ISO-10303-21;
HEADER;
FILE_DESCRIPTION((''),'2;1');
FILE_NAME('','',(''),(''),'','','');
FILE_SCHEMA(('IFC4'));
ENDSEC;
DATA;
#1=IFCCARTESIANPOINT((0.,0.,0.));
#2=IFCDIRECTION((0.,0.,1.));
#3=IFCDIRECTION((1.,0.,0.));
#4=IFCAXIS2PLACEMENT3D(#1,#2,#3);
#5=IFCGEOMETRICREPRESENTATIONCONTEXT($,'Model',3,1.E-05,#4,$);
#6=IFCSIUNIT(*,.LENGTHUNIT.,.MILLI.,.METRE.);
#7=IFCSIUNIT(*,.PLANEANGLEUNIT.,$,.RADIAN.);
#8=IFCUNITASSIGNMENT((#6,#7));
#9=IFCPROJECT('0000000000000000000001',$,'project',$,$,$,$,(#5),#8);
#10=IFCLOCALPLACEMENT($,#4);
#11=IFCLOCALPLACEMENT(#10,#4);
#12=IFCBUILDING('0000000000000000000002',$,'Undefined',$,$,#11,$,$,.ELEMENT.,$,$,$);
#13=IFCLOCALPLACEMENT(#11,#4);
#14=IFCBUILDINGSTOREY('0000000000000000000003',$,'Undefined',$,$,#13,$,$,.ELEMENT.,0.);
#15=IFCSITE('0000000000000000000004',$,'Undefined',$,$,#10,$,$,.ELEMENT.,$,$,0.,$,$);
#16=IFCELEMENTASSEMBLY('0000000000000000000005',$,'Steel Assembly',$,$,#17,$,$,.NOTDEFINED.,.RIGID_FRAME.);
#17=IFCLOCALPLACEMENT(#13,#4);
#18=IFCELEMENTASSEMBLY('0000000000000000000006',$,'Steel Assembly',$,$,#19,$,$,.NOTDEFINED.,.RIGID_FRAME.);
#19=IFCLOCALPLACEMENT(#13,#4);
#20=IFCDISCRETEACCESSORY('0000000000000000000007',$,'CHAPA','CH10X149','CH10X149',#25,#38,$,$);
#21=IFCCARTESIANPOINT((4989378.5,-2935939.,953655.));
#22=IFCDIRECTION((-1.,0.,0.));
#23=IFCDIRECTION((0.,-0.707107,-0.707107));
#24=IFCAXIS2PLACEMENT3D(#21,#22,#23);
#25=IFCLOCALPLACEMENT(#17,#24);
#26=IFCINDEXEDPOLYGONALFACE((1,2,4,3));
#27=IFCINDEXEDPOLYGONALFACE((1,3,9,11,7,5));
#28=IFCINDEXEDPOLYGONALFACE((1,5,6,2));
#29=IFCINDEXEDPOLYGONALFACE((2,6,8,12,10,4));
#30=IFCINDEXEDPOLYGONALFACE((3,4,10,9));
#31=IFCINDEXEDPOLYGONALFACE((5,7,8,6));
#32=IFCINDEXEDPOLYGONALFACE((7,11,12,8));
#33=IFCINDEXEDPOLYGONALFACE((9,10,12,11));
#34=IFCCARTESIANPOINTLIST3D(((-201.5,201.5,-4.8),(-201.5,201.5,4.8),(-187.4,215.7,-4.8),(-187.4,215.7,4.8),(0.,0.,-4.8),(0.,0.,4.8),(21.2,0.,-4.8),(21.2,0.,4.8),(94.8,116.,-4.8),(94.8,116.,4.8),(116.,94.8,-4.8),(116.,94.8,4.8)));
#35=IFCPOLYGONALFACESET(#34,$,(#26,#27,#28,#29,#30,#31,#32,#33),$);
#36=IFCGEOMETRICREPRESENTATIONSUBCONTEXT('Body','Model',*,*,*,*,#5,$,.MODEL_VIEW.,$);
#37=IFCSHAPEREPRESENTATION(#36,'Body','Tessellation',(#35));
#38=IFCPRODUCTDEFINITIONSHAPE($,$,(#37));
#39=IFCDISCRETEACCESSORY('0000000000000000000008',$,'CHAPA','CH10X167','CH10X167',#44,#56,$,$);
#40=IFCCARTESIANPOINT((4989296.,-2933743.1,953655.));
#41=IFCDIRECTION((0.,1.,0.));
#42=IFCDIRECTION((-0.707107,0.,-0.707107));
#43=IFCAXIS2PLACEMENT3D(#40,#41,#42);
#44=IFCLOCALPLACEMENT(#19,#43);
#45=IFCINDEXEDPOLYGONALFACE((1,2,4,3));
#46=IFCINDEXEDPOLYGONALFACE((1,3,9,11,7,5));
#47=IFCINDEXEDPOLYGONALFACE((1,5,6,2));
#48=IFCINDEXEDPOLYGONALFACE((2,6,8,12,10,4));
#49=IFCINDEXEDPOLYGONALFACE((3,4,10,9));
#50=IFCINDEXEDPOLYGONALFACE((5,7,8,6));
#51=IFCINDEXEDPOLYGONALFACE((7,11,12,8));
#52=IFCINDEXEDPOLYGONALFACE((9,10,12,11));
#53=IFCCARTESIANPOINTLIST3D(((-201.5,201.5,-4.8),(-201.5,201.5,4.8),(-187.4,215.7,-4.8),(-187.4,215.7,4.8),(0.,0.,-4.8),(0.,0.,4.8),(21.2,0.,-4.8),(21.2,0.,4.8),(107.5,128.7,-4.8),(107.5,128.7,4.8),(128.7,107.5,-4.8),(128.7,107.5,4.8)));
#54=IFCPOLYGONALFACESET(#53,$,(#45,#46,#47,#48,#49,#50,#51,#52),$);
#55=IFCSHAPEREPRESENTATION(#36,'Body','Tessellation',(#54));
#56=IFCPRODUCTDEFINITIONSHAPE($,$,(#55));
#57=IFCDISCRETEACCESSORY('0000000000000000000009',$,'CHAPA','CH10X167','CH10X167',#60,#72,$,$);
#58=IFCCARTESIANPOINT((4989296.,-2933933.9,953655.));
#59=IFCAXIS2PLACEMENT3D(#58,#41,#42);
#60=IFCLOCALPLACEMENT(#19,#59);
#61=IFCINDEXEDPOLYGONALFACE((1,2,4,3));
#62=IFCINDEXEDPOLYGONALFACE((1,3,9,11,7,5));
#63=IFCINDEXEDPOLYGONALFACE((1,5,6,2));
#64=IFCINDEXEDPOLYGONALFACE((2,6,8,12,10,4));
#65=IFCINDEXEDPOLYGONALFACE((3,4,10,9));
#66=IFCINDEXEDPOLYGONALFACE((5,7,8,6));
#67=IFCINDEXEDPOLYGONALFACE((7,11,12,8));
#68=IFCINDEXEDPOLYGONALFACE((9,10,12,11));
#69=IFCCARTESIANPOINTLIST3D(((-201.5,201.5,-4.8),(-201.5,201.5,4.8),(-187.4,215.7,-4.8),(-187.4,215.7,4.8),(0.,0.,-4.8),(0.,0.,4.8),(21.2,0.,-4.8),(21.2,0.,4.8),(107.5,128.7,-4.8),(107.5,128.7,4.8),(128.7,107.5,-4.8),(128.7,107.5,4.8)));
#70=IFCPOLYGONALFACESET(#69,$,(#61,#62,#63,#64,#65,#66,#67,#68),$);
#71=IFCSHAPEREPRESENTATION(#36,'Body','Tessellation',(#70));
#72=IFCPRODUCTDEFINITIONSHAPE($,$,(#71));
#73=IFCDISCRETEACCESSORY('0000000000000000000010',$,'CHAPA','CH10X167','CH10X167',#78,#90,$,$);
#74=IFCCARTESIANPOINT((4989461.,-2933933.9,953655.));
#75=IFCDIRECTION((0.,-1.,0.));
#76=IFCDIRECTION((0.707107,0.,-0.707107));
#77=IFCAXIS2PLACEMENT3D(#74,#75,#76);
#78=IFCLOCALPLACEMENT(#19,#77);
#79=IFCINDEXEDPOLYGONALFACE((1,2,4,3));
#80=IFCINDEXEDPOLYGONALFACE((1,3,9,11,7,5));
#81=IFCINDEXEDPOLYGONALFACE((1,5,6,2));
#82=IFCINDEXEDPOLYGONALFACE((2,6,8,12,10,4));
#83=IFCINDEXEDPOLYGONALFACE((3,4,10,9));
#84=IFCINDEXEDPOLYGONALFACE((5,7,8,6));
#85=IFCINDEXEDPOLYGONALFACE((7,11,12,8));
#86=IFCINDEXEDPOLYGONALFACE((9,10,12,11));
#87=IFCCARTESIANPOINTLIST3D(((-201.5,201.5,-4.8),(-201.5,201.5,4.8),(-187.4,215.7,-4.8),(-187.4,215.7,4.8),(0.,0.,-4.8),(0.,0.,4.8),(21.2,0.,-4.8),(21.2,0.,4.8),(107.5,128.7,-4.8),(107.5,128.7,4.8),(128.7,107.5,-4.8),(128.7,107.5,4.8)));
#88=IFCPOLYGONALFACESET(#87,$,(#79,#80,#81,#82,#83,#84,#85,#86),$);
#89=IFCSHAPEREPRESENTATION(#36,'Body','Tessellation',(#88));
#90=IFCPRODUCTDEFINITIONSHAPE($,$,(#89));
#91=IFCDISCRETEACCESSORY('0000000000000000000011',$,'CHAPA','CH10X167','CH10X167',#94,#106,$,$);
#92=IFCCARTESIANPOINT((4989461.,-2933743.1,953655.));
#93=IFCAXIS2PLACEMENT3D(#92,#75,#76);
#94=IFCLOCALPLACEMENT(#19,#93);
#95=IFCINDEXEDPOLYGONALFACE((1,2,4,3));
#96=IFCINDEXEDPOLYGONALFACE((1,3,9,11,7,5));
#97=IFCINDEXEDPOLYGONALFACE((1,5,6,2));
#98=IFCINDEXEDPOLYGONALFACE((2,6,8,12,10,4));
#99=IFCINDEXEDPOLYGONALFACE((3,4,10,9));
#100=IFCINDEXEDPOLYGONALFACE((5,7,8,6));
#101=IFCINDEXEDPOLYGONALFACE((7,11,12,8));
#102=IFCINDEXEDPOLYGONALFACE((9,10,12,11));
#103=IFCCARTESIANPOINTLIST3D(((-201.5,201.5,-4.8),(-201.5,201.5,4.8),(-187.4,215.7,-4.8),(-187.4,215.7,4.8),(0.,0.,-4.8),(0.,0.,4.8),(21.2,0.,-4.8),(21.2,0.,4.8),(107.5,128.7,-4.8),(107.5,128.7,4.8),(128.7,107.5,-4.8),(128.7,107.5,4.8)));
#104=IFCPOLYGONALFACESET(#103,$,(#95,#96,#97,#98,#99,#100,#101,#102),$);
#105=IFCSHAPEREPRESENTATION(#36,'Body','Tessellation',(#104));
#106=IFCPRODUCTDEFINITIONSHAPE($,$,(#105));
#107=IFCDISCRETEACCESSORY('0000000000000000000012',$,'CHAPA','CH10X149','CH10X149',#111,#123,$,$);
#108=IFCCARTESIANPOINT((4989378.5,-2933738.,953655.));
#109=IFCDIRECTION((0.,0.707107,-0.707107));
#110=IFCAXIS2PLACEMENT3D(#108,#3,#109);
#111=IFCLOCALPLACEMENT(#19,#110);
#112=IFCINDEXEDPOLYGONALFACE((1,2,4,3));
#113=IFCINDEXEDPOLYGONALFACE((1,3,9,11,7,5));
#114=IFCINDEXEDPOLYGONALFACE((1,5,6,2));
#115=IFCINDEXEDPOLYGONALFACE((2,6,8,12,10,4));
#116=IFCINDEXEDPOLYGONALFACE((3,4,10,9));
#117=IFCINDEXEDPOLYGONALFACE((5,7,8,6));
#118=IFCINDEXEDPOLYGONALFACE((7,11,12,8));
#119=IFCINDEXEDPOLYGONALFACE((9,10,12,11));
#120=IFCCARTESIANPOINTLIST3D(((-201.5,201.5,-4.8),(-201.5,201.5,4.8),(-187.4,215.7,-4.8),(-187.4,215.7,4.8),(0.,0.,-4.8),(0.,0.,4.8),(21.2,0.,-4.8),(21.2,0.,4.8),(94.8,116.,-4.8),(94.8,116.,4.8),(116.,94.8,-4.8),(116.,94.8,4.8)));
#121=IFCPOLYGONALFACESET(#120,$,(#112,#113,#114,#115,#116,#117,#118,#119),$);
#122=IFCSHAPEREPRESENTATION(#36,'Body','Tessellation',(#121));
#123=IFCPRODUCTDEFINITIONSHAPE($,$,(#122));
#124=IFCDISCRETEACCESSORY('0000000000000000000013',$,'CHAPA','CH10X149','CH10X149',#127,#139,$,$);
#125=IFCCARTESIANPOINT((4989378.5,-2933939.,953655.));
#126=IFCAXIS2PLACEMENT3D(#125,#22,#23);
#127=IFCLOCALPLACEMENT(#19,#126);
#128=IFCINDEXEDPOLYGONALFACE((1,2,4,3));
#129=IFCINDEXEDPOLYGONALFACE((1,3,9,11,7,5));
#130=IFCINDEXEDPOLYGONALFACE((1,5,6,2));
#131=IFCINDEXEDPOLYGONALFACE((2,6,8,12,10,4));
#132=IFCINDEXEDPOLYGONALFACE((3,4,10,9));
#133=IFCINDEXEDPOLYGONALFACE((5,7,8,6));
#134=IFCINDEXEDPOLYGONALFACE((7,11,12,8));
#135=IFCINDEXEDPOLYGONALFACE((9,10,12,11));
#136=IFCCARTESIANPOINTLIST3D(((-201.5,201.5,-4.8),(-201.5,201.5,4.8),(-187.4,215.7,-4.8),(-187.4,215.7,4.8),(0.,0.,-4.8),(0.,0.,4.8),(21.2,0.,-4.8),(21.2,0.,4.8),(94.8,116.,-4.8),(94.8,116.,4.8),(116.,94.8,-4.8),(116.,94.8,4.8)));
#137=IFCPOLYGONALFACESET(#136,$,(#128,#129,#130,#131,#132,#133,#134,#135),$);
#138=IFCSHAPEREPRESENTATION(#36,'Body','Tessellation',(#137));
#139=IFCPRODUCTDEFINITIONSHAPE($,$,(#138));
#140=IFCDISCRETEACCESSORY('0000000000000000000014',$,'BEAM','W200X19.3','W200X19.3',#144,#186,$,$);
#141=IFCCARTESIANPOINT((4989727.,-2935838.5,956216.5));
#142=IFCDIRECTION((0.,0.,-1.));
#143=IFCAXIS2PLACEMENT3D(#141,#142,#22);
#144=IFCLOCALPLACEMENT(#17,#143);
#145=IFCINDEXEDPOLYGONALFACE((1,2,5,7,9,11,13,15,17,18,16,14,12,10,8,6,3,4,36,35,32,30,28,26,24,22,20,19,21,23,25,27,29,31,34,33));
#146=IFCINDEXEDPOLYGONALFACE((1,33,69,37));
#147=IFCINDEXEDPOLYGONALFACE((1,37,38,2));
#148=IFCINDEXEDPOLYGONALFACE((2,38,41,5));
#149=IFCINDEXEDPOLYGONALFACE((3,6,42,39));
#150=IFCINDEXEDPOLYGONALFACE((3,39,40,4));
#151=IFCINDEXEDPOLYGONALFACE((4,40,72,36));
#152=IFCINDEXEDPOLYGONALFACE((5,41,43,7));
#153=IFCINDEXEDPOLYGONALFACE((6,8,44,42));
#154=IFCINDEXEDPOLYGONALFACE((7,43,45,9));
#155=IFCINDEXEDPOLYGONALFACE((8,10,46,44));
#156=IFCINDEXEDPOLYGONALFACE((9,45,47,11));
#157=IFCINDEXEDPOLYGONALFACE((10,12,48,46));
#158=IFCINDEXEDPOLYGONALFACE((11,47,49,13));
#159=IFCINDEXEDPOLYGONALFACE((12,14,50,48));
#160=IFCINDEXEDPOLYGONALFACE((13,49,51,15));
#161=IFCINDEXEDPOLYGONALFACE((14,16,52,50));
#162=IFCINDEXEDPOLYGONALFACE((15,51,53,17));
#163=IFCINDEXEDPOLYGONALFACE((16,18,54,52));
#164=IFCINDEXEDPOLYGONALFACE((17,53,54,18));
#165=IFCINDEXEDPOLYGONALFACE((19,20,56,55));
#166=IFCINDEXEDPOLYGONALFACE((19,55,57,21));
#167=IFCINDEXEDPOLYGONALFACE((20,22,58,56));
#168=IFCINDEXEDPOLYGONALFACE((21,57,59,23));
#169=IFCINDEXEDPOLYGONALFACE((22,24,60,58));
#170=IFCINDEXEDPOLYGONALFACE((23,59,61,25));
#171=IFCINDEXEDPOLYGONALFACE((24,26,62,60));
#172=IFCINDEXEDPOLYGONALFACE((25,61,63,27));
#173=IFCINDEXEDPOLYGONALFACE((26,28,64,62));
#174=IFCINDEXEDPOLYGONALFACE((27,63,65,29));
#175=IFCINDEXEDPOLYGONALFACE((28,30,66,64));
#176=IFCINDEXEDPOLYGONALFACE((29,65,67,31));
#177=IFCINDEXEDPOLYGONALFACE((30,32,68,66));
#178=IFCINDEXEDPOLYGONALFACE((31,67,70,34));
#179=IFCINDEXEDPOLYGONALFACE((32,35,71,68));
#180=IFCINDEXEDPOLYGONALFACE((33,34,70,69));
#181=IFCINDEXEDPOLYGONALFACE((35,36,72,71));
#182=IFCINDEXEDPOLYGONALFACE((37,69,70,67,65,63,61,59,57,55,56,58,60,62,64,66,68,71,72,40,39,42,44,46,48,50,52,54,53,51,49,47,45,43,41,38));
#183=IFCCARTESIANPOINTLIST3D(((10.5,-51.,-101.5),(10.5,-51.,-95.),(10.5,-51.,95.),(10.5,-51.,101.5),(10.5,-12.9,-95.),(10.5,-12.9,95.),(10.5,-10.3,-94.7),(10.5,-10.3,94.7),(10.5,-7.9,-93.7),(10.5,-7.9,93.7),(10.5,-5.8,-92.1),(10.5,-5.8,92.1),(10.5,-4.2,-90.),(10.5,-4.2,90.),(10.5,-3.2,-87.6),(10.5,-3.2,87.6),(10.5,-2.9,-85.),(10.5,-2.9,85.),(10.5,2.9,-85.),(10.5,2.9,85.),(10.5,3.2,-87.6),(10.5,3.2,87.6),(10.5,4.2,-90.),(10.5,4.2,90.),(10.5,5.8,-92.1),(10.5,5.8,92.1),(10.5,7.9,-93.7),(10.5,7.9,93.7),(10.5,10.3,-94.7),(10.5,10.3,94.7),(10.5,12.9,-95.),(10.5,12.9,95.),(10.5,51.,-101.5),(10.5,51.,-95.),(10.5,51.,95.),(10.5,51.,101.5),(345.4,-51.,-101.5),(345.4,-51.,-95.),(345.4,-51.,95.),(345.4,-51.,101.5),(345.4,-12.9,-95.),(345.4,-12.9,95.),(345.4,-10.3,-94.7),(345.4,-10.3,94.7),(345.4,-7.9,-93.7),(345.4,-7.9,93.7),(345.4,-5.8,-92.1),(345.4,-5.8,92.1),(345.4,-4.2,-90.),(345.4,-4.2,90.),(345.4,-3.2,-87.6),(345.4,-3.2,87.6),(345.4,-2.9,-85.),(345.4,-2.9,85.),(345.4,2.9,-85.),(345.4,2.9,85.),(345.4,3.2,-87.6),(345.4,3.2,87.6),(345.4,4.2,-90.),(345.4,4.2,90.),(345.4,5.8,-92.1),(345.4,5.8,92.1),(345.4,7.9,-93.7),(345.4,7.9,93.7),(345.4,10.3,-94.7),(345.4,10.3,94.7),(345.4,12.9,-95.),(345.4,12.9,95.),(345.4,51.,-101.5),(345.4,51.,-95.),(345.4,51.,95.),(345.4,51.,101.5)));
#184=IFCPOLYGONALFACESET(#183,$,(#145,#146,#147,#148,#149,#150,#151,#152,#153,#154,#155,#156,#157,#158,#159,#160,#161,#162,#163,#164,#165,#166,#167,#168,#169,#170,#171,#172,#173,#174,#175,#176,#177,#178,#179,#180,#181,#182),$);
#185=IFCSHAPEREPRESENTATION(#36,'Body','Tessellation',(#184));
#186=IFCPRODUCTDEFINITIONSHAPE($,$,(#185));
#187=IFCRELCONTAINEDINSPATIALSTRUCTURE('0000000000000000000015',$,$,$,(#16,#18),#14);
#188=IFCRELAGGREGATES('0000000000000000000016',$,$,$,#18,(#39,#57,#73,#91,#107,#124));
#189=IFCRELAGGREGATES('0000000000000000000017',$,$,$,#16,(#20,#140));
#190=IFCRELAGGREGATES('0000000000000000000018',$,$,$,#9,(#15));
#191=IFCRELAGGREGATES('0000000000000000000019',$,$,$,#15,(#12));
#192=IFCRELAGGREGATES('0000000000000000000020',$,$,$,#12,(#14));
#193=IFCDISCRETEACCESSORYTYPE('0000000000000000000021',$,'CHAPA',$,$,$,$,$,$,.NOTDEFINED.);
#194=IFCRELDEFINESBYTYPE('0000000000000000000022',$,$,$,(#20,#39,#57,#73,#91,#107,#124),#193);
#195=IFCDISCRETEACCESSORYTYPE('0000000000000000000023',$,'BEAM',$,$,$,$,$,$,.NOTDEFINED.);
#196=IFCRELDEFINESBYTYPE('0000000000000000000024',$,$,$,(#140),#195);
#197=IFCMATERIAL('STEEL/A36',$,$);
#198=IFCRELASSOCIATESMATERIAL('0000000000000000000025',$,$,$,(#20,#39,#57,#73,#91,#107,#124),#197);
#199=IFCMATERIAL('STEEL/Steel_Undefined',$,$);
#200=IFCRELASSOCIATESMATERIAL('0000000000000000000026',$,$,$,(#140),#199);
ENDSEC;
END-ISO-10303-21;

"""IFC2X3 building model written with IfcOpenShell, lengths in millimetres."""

from ifc_helpers import new_model, si_unit, frame, origin_with_axes, origin_2d_with_axis, place, context, subcontext, project, spatial, polyline, i_section, outline, extrude, clip, halfspace, material, type_object, element, aggregate, save


model = new_model("IFC2X3")

# Units and contexts
model_context = context("Model", 3, precision=1e-05, world=origin_with_axes())
body_context = subcontext(model_context, "Body", "Model", "MODEL_VIEW")
ifc_project = project(units=[si_unit("LENGTHUNIT", "METRE", prefix="MILLI"), si_unit("PLANEANGLEUNIT", "RADIAN")], contexts=[model_context])

# Site, building, storey
site_placement = place(None, origin_with_axes())
site = spatial("IfcSite", under=ifc_project, at=site_placement, Name="Undefined", CompositionType="ELEMENT", RefElevation=0.0)
building_placement = place(site_placement, origin_with_axes())
building = spatial("IfcBuilding", under=site, at=building_placement, Name="Undefined", CompositionType="ELEMENT")
storey_placement = place(building_placement, origin_with_axes())
storey = spatial("IfcBuildingStorey", under=building, at=storey_placement, Name="Undefined", CompositionType="ELEMENT", Elevation=0.0)

# Element assemblies
assembly_1_placement = place(storey_placement, origin_with_axes())
assembly_1 = element("IfcElementAssembly", 1, at=assembly_1_placement, inside=storey, Name="Steel Assembly", AssemblyPlace="NOTDEFINED", PredefinedType="RIGID_FRAME")
assembly_2_placement = place(storey_placement, origin_with_axes())
assembly_2 = element("IfcElementAssembly", 2, at=assembly_2_placement, inside=storey, Name="Steel Assembly", AssemblyPlace="NOTDEFINED", PredefinedType="RIGID_FRAME")

# Discrete accessories
ifc_material_1 = material(Name="STEEL/A36")
discrete_accessory_type_1 = type_object("IfcDiscreteAccessoryType", Name="CHAPA")
discrete_accessory_1_placement = place(assembly_1_placement, frame((4989378.5, -2935939.0, 953655.0), z_axis=(-1.0, 0.0, 0.0), x_axis=(0.0, -0.707107, -0.707107)))
discrete_accessory_1 = element("IfcDiscreteAccessory", 3, at=discrete_accessory_1_placement, type_object=discrete_accessory_type_1, material=ifc_material_1, Name="CHAPA", Description="CH10X149", ObjectType="CH10X149", context=body_context, shape_type="SweptSolid", body=[
    extrude(outline(polyline([(0.0, 0.0), (21.2, 0.0), (116.0, 94.8), (94.8, 116.0), (-187.4, 215.7), (-201.5, 201.5), (0.0, 0.0)])), frame((0.0, 0.0, -4.8), z_axis=(0.0, 0.0, 1.0), x_axis=(1.0, 0.0, 0.0)), (0.0, 0.0, 1.0), 9.5),
])
discrete_accessory_2_placement = place(assembly_2_placement, frame((4989296.0, -2933743.1, 953655.0), z_axis=(0.0, 1.0, 0.0), x_axis=(-0.707107, 0.0, -0.707107)))
discrete_accessory_2 = element("IfcDiscreteAccessory", 4, at=discrete_accessory_2_placement, type_object=discrete_accessory_type_1, material=ifc_material_1, Name="CHAPA", Description="CH10X167", ObjectType="CH10X167", context=body_context, shape_type="SweptSolid", body=[
    extrude(outline(polyline([(0.0, 0.0), (21.2, 0.0), (128.7, 107.5), (107.5, 128.7), (-187.4, 215.7), (-201.5, 201.5), (0.0, 0.0)])), frame((0.0, 0.0, -4.8), z_axis=(0.0, 0.0, 1.0), x_axis=(1.0, 0.0, 0.0)), (0.0, 0.0, 1.0), 9.5),
])
discrete_accessory_3_placement = place(assembly_2_placement, frame((4989296.0, -2933933.9, 953655.0), z_axis=(0.0, 1.0, 0.0), x_axis=(-0.707107, 0.0, -0.707107)))
discrete_accessory_3 = element("IfcDiscreteAccessory", 5, at=discrete_accessory_3_placement, type_object=discrete_accessory_type_1, material=ifc_material_1, Name="CHAPA", Description="CH10X167", ObjectType="CH10X167", context=body_context, shape_type="SweptSolid", body=[
    extrude(outline(polyline([(0.0, 0.0), (21.2, 0.0), (128.7, 107.5), (107.5, 128.7), (-187.4, 215.7), (-201.5, 201.5), (0.0, 0.0)])), frame((0.0, 0.0, -4.8), z_axis=(0.0, 0.0, 1.0), x_axis=(1.0, 0.0, 0.0)), (0.0, 0.0, 1.0), 9.5),
])
discrete_accessory_4_placement = place(assembly_2_placement, frame((4989461.0, -2933933.9, 953655.0), z_axis=(0.0, -1.0, 0.0), x_axis=(0.707107, 0.0, -0.707107)))
discrete_accessory_4 = element("IfcDiscreteAccessory", 6, at=discrete_accessory_4_placement, type_object=discrete_accessory_type_1, material=ifc_material_1, Name="CHAPA", Description="CH10X167", ObjectType="CH10X167", context=body_context, shape_type="SweptSolid", body=[
    extrude(outline(polyline([(0.0, 0.0), (21.2, 0.0), (128.7, 107.5), (107.5, 128.7), (-187.4, 215.7), (-201.5, 201.5), (0.0, 0.0)])), frame((0.0, 0.0, -4.8), z_axis=(0.0, 0.0, 1.0), x_axis=(1.0, 0.0, 0.0)), (0.0, 0.0, 1.0), 9.5),
])
discrete_accessory_5_placement = place(assembly_2_placement, frame((4989461.0, -2933743.1, 953655.0), z_axis=(0.0, -1.0, 0.0), x_axis=(0.707107, 0.0, -0.707107)))
discrete_accessory_5 = element("IfcDiscreteAccessory", 7, at=discrete_accessory_5_placement, type_object=discrete_accessory_type_1, material=ifc_material_1, Name="CHAPA", Description="CH10X167", ObjectType="CH10X167", context=body_context, shape_type="SweptSolid", body=[
    extrude(outline(polyline([(0.0, 0.0), (21.2, 0.0), (128.7, 107.5), (107.5, 128.7), (-187.4, 215.7), (-201.5, 201.5), (0.0, 0.0)])), frame((0.0, 0.0, -4.8), z_axis=(0.0, 0.0, 1.0), x_axis=(1.0, 0.0, 0.0)), (0.0, 0.0, 1.0), 9.5),
])
discrete_accessory_6_placement = place(assembly_2_placement, frame((4989378.5, -2933738.0, 953655.0), z_axis=(1.0, 0.0, 0.0), x_axis=(0.0, 0.707107, -0.707107)))
discrete_accessory_6 = element("IfcDiscreteAccessory", 8, at=discrete_accessory_6_placement, type_object=discrete_accessory_type_1, material=ifc_material_1, Name="CHAPA", Description="CH10X149", ObjectType="CH10X149", context=body_context, shape_type="SweptSolid", body=[
    extrude(outline(polyline([(0.0, 0.0), (21.2, 0.0), (116.0, 94.8), (94.8, 116.0), (-187.4, 215.7), (-201.5, 201.5), (0.0, 0.0)])), frame((0.0, 0.0, -4.8), z_axis=(0.0, 0.0, 1.0), x_axis=(1.0, 0.0, 0.0)), (0.0, 0.0, 1.0), 9.5),
])
discrete_accessory_7_placement = place(assembly_2_placement, frame((4989378.5, -2933939.0, 953655.0), z_axis=(-1.0, 0.0, 0.0), x_axis=(0.0, -0.707107, -0.707107)))
discrete_accessory_7 = element("IfcDiscreteAccessory", 9, at=discrete_accessory_7_placement, type_object=discrete_accessory_type_1, material=ifc_material_1, Name="CHAPA", Description="CH10X149", ObjectType="CH10X149", context=body_context, shape_type="SweptSolid", body=[
    extrude(outline(polyline([(0.0, 0.0), (21.2, 0.0), (116.0, 94.8), (94.8, 116.0), (-187.4, 215.7), (-201.5, 201.5), (0.0, 0.0)])), frame((0.0, 0.0, -4.8), z_axis=(0.0, 0.0, 1.0), x_axis=(1.0, 0.0, 0.0)), (0.0, 0.0, 1.0), 9.5),
])
aggregate(assembly_2, [discrete_accessory_2, discrete_accessory_3, discrete_accessory_4, discrete_accessory_5, discrete_accessory_6, discrete_accessory_7])

# Discrete accessory
ifc_material_2 = material(Name="STEEL/Steel_Undefined")
discrete_accessory_type_2 = type_object("IfcDiscreteAccessoryType", Name="BEAM")
discrete_accessory_8_placement = place(assembly_1_placement, frame((4989727.0, -2935838.5, 956216.5), z_axis=(0.0, 0.0, -1.0), x_axis=(-1.0, 0.0, 0.0)))
discrete_accessory_8 = element("IfcDiscreteAccessory", 10, at=discrete_accessory_8_placement, type_object=discrete_accessory_type_2, material=ifc_material_2, Name="BEAM", Description="W200X19.3", ObjectType="W200X19.3", context=body_context, shape_type="Clipping", body=[
    clip(clip(extrude(i_section(OverallWidth=102.0, OverallDepth=203.0, WebThickness=5.8, FlangeThickness=6.5, FilletRadius=10.0, at=origin_2d_with_axis()), frame((345.4, 0.0, 0.0), z_axis=(-1.0, 0.0, 0.0), x_axis=(0.0, -1.0, 0.0)), (0.0, 0.0, 1.0), 334.9), halfspace(frame((345.4, 0.0, -1101.5), z_axis=(1.0, 0.0, 0.0), x_axis=(0.0, -1.0, 0.0)), False)), halfspace(frame((10.5, 0.0, -1000.0), z_axis=(1.0, 0.0, 0.0), x_axis=(0.0, -1.0, 0.0)), True)),
])
aggregate(assembly_1, [discrete_accessory_1, discrete_accessory_8])

save(model, "model.ifc")
